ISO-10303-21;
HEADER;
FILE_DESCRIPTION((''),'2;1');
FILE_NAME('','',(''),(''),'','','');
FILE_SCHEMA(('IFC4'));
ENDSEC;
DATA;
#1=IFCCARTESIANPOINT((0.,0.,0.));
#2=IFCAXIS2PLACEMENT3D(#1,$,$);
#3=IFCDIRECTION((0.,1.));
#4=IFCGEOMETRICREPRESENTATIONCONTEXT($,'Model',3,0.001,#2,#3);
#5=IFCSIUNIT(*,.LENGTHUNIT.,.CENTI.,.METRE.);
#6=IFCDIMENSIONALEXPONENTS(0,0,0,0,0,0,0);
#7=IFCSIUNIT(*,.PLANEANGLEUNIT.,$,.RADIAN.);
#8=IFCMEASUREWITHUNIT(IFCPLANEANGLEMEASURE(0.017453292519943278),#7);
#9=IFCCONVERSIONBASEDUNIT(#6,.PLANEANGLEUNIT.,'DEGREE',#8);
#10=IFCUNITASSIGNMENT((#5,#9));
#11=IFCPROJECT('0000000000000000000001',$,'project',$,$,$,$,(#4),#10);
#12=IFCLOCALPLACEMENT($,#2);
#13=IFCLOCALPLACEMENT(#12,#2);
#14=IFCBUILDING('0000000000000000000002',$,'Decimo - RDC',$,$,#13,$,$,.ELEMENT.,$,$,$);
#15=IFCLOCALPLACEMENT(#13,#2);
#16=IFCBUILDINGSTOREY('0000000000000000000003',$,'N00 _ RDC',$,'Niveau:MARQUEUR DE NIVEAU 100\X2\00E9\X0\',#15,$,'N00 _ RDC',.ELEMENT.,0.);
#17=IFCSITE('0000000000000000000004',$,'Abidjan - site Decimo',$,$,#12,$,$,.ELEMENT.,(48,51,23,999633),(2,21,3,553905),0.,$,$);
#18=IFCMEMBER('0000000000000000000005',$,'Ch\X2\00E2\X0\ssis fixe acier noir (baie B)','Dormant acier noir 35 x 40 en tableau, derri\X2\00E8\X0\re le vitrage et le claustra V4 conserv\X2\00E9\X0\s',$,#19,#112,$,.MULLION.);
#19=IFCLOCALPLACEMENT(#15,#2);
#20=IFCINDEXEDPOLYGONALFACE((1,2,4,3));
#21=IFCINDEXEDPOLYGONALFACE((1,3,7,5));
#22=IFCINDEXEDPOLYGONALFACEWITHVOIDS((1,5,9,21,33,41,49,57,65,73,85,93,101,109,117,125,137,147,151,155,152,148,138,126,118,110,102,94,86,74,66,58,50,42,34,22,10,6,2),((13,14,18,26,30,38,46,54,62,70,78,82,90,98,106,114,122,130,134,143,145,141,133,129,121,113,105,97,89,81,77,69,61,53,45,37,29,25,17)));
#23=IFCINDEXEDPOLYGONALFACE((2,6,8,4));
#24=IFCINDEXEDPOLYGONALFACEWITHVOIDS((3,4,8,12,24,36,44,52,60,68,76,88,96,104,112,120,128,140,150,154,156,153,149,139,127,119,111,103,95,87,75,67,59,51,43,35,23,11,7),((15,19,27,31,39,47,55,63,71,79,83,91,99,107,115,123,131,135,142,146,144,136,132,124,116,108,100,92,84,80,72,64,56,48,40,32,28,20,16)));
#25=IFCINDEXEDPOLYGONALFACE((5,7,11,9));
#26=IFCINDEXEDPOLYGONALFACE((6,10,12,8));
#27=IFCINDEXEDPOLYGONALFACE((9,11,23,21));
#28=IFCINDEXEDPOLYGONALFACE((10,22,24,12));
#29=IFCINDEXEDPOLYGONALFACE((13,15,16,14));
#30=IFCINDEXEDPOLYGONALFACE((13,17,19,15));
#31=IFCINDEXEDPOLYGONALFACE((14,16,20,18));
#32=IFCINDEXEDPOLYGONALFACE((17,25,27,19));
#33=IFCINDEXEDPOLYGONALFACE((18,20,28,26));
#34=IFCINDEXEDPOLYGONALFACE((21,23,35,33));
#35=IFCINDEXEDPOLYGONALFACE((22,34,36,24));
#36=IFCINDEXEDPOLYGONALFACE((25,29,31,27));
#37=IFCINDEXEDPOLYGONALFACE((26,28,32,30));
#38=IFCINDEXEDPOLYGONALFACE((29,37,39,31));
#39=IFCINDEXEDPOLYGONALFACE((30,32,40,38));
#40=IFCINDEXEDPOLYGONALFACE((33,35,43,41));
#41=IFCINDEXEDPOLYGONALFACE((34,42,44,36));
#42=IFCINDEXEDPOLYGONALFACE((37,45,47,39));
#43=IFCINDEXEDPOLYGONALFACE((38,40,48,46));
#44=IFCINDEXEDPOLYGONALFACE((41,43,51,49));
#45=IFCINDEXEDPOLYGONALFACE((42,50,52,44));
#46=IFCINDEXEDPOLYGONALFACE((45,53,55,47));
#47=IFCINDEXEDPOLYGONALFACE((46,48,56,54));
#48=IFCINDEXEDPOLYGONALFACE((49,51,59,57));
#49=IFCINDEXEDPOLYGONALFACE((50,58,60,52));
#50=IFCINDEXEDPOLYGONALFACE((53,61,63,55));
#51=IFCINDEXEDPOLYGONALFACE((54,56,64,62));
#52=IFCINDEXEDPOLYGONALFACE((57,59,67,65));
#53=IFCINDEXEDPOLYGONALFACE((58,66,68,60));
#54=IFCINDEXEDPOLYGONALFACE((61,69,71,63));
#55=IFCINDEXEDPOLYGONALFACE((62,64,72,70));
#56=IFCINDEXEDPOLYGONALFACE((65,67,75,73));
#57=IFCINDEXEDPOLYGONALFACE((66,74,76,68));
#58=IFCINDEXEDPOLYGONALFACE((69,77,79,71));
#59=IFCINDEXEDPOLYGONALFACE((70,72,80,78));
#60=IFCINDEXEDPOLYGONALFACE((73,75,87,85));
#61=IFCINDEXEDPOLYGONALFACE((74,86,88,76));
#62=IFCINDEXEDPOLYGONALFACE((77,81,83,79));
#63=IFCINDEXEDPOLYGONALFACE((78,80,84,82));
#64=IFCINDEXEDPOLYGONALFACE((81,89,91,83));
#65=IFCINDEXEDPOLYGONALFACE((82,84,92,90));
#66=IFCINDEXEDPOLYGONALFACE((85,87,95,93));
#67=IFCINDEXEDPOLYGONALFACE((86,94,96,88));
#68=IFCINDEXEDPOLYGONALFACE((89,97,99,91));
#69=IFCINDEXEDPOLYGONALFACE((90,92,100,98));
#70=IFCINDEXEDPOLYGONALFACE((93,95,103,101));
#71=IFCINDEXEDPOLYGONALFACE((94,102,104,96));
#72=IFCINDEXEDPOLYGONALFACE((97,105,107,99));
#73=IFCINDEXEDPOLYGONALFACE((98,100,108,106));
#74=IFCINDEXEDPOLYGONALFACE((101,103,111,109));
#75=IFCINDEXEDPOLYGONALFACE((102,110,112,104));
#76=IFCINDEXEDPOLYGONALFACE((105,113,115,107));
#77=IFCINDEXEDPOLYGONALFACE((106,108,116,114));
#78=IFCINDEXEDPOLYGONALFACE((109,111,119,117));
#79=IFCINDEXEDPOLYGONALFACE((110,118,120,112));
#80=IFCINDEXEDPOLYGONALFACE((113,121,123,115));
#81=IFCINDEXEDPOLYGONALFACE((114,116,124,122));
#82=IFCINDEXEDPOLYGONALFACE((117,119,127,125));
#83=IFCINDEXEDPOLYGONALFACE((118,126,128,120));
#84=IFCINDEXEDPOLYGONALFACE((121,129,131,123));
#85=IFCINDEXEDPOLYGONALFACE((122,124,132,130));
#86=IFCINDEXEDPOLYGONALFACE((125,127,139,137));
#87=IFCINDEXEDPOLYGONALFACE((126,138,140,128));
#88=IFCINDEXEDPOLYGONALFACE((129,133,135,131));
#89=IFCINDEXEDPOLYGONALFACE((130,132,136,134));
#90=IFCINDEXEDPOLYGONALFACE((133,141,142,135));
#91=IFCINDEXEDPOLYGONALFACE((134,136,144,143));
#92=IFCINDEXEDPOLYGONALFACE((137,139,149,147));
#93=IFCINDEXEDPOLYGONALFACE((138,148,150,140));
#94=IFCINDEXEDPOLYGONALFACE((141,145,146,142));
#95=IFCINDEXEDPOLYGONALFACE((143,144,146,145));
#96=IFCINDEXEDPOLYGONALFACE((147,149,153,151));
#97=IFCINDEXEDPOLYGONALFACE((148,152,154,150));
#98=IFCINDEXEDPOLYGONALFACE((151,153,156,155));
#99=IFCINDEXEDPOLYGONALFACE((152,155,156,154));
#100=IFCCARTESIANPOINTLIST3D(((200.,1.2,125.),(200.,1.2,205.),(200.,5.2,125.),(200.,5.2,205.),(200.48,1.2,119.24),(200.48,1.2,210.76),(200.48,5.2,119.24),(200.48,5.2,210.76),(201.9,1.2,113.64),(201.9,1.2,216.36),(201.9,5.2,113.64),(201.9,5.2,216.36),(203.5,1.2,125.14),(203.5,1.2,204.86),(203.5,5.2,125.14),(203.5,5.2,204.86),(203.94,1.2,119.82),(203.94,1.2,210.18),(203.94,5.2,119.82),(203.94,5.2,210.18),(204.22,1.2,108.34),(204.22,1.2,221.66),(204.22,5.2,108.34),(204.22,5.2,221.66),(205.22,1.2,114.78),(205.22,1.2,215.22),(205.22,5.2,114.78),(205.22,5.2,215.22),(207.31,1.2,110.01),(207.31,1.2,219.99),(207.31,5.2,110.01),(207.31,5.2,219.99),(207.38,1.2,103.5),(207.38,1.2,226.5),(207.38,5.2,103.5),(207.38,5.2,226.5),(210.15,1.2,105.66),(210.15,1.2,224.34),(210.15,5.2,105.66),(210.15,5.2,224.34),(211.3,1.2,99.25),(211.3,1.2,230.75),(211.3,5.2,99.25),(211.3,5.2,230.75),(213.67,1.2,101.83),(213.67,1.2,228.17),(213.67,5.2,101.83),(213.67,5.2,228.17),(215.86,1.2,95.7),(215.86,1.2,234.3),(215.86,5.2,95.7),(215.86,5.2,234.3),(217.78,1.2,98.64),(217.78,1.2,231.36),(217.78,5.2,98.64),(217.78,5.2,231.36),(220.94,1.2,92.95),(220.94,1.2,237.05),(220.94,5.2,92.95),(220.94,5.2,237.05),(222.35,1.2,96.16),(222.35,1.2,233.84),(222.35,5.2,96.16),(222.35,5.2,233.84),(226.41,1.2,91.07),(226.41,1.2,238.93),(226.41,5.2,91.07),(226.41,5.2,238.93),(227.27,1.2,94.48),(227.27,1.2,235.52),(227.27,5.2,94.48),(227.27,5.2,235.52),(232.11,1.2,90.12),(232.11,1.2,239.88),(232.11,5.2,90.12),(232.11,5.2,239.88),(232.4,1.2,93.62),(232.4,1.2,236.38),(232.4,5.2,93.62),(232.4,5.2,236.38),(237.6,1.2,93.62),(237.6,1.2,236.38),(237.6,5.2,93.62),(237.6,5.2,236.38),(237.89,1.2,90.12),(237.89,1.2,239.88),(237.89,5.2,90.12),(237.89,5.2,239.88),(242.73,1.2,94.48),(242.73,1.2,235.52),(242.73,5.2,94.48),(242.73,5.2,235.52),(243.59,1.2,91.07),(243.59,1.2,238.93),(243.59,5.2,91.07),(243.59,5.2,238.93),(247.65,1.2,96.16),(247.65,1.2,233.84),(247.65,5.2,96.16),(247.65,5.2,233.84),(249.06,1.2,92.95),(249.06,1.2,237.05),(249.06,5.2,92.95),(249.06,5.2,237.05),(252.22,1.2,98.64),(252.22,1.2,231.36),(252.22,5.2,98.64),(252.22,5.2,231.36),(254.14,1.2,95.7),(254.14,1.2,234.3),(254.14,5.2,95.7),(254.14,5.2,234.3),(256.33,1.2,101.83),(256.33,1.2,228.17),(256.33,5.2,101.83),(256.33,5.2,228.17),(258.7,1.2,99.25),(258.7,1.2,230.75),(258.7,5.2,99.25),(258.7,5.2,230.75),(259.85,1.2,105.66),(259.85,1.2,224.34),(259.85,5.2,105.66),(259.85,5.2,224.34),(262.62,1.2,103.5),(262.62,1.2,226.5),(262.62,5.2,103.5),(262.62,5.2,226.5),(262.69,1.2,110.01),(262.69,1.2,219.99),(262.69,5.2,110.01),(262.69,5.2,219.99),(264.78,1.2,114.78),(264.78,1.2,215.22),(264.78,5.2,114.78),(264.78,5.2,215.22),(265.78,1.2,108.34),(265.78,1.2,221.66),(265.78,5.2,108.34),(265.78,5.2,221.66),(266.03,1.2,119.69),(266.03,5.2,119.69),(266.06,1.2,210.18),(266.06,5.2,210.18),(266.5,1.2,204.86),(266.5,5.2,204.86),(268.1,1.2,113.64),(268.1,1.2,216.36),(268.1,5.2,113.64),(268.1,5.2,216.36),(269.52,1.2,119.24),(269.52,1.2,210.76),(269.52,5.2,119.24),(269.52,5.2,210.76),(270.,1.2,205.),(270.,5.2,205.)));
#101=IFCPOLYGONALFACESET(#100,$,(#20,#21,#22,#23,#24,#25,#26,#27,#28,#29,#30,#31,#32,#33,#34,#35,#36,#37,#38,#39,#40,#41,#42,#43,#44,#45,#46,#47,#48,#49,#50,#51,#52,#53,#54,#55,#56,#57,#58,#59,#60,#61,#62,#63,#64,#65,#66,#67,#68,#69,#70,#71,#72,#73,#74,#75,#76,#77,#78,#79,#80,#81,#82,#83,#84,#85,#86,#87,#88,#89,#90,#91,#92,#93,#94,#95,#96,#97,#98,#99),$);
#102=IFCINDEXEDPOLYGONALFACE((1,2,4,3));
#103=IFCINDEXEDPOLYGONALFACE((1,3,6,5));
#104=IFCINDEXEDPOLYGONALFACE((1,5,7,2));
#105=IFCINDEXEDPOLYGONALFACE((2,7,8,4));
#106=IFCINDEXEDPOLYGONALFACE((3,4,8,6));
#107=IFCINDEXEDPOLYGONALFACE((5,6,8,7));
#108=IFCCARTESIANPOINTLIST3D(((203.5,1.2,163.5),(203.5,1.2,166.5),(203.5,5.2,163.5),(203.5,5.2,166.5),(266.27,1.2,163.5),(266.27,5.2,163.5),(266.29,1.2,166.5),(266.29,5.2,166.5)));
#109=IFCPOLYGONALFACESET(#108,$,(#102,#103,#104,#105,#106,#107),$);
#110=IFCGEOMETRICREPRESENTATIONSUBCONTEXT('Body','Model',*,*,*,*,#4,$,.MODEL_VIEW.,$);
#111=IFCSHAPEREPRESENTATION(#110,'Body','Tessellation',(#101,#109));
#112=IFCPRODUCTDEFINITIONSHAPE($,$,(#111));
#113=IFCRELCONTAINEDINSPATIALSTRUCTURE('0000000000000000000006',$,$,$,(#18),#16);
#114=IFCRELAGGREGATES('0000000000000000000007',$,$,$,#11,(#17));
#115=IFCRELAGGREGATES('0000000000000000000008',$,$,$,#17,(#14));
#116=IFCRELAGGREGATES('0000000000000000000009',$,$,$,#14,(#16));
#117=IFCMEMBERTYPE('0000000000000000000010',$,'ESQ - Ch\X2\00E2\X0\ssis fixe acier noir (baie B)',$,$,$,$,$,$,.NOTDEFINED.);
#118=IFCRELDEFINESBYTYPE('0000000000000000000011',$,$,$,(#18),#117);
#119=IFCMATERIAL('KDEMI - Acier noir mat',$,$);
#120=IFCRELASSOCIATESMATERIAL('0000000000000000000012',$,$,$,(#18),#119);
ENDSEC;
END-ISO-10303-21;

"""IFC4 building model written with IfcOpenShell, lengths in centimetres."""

from ifc_helpers import new_model, entity, si_unit, converted_unit, direction, frame, origin, origin_with_axes, place, context, subcontext, project, spatial, polyline, outline, extrude, material, type_object, element, save


model = new_model("IFC4")

# Units and contexts
model_context = context("Model", 3, precision=0.001, world=origin(), true_north=direction((0.0, 1.0)))
body_context = subcontext(model_context, "Body", "Model", "MODEL_VIEW")
ifc_project = project(units=[si_unit("LENGTHUNIT", "METRE", prefix="CENTI"), converted_unit("PLANEANGLEUNIT", "DEGREE", entity("IfcPlaneAngleMeasure", 0.017453292519943278), si_unit("PLANEANGLEUNIT", "RADIAN"), dimensions=[0, 0, 0, 0, 0, 0, 0])], contexts=[model_context])

# Site, building, storey
site_placement = place(None, origin())
site = spatial("IfcSite", under=ifc_project, at=site_placement, Name="Abidjan - site Decimo", CompositionType="ELEMENT", RefLatitude=(48, 51, 23, 999633), RefLongitude=(2, 21, 3, 553905), RefElevation=0.0)
building_placement = place(site_placement, origin())
building = spatial("IfcBuilding", under=site, at=building_placement, Name="Decimo - RDC", CompositionType="ELEMENT")
storey_placement = place(building_placement, origin())
storey = spatial("IfcBuildingStorey", under=building, at=storey_placement, Name="N00 _ RDC", ObjectType="Niveau:MARQUEUR DE NIVEAU 100é", LongName="N00 _ RDC", CompositionType="ELEMENT", Elevation=0.0)

# Member
ifc_material_1 = material(Name="KDEMI - Acier noir mat")
member_type_1 = type_object("IfcMemberType", Name="ESQ - Châssis fixe acier noir (baie B)", PredefinedType="NOTDEFINED")
member_1_placement = place(storey_placement, origin_with_axes())
element("IfcMember", 1, at=member_1_placement, inside=storey, type_object=member_type_1, material=ifc_material_1, Name="Châssis fixe acier noir (baie B)", Description="Dormant acier noir 35 x 40 en tableau, derrière le vitrage et le claustra V4 conservés", PredefinedType="MULLION", context=body_context, shape_type="SweptSolid", body=[
    extrude(outline(polyline([(269.52, 119.24), (268.1, 113.64), (265.78, 108.34), (262.62, 103.5), (258.7, 99.25), (254.14, 95.7), (249.06, 92.95), (243.59, 91.07), (237.89, 90.12), (232.11, 90.12), (226.41, 91.07), (220.94, 92.95), (215.86, 95.7), (211.3, 99.25), (207.38, 103.5), (204.22, 108.34), (201.9, 113.64), (200.48, 119.24), (200.0, 125.0), (200.0, 205.0), (200.48, 210.76), (201.9, 216.36), (204.22, 221.66), (207.38, 226.5), (211.3, 230.75), (215.86, 234.3), (220.94, 237.05), (226.41, 238.93), (232.11, 239.88), (237.89, 239.88), (243.59, 238.93), (249.06, 237.05), (254.14, 234.3), (258.7, 230.75), (262.62, 226.5), (265.78, 221.66), (268.1, 216.36), (269.52, 210.76), (270.0, 205.0), (269.52, 119.24)]), holes=[polyline([(266.06, 210.18), (264.78, 215.22), (262.69, 219.99), (259.85, 224.34), (256.33, 228.17), (252.22, 231.36), (247.65, 233.84), (242.73, 235.52), (237.6, 236.38), (232.4, 236.38), (227.27, 235.52), (222.35, 233.84), (217.78, 231.36), (213.67, 228.17), (210.15, 224.34), (207.31, 219.99), (205.22, 215.22), (203.94, 210.18), (203.5, 204.86), (203.5, 125.14), (203.94, 119.82), (205.22, 114.78), (207.31, 110.01), (210.15, 105.66), (213.67, 101.83), (217.78, 98.64), (222.35, 96.16), (227.27, 94.48), (232.4, 93.62), (237.6, 93.62), (242.73, 94.48), (247.65, 96.16), (252.22, 98.64), (256.33, 101.83), (259.85, 105.66), (262.69, 110.01), (264.78, 114.78), (266.03, 119.69), (266.5, 204.86), (266.06, 210.18)])]), frame((0.0, 5.2, 0.0), z_axis=(0.0, -1.0, 0.0), x_axis=(1.0, 0.0, 0.0)), (0.0, 0.0, 1.0), 4.0),
    extrude(outline(polyline([(266.29, 166.5), (266.27, 163.5), (203.5, 163.5), (203.5, 166.5), (266.29, 166.5)])), frame((0.0, 5.2, 0.0), z_axis=(0.0, -1.0, 0.0), x_axis=(1.0, 0.0, 0.0)), (0.0, 0.0, 1.0), 4.0),
])

save(model, "model.ifc")
